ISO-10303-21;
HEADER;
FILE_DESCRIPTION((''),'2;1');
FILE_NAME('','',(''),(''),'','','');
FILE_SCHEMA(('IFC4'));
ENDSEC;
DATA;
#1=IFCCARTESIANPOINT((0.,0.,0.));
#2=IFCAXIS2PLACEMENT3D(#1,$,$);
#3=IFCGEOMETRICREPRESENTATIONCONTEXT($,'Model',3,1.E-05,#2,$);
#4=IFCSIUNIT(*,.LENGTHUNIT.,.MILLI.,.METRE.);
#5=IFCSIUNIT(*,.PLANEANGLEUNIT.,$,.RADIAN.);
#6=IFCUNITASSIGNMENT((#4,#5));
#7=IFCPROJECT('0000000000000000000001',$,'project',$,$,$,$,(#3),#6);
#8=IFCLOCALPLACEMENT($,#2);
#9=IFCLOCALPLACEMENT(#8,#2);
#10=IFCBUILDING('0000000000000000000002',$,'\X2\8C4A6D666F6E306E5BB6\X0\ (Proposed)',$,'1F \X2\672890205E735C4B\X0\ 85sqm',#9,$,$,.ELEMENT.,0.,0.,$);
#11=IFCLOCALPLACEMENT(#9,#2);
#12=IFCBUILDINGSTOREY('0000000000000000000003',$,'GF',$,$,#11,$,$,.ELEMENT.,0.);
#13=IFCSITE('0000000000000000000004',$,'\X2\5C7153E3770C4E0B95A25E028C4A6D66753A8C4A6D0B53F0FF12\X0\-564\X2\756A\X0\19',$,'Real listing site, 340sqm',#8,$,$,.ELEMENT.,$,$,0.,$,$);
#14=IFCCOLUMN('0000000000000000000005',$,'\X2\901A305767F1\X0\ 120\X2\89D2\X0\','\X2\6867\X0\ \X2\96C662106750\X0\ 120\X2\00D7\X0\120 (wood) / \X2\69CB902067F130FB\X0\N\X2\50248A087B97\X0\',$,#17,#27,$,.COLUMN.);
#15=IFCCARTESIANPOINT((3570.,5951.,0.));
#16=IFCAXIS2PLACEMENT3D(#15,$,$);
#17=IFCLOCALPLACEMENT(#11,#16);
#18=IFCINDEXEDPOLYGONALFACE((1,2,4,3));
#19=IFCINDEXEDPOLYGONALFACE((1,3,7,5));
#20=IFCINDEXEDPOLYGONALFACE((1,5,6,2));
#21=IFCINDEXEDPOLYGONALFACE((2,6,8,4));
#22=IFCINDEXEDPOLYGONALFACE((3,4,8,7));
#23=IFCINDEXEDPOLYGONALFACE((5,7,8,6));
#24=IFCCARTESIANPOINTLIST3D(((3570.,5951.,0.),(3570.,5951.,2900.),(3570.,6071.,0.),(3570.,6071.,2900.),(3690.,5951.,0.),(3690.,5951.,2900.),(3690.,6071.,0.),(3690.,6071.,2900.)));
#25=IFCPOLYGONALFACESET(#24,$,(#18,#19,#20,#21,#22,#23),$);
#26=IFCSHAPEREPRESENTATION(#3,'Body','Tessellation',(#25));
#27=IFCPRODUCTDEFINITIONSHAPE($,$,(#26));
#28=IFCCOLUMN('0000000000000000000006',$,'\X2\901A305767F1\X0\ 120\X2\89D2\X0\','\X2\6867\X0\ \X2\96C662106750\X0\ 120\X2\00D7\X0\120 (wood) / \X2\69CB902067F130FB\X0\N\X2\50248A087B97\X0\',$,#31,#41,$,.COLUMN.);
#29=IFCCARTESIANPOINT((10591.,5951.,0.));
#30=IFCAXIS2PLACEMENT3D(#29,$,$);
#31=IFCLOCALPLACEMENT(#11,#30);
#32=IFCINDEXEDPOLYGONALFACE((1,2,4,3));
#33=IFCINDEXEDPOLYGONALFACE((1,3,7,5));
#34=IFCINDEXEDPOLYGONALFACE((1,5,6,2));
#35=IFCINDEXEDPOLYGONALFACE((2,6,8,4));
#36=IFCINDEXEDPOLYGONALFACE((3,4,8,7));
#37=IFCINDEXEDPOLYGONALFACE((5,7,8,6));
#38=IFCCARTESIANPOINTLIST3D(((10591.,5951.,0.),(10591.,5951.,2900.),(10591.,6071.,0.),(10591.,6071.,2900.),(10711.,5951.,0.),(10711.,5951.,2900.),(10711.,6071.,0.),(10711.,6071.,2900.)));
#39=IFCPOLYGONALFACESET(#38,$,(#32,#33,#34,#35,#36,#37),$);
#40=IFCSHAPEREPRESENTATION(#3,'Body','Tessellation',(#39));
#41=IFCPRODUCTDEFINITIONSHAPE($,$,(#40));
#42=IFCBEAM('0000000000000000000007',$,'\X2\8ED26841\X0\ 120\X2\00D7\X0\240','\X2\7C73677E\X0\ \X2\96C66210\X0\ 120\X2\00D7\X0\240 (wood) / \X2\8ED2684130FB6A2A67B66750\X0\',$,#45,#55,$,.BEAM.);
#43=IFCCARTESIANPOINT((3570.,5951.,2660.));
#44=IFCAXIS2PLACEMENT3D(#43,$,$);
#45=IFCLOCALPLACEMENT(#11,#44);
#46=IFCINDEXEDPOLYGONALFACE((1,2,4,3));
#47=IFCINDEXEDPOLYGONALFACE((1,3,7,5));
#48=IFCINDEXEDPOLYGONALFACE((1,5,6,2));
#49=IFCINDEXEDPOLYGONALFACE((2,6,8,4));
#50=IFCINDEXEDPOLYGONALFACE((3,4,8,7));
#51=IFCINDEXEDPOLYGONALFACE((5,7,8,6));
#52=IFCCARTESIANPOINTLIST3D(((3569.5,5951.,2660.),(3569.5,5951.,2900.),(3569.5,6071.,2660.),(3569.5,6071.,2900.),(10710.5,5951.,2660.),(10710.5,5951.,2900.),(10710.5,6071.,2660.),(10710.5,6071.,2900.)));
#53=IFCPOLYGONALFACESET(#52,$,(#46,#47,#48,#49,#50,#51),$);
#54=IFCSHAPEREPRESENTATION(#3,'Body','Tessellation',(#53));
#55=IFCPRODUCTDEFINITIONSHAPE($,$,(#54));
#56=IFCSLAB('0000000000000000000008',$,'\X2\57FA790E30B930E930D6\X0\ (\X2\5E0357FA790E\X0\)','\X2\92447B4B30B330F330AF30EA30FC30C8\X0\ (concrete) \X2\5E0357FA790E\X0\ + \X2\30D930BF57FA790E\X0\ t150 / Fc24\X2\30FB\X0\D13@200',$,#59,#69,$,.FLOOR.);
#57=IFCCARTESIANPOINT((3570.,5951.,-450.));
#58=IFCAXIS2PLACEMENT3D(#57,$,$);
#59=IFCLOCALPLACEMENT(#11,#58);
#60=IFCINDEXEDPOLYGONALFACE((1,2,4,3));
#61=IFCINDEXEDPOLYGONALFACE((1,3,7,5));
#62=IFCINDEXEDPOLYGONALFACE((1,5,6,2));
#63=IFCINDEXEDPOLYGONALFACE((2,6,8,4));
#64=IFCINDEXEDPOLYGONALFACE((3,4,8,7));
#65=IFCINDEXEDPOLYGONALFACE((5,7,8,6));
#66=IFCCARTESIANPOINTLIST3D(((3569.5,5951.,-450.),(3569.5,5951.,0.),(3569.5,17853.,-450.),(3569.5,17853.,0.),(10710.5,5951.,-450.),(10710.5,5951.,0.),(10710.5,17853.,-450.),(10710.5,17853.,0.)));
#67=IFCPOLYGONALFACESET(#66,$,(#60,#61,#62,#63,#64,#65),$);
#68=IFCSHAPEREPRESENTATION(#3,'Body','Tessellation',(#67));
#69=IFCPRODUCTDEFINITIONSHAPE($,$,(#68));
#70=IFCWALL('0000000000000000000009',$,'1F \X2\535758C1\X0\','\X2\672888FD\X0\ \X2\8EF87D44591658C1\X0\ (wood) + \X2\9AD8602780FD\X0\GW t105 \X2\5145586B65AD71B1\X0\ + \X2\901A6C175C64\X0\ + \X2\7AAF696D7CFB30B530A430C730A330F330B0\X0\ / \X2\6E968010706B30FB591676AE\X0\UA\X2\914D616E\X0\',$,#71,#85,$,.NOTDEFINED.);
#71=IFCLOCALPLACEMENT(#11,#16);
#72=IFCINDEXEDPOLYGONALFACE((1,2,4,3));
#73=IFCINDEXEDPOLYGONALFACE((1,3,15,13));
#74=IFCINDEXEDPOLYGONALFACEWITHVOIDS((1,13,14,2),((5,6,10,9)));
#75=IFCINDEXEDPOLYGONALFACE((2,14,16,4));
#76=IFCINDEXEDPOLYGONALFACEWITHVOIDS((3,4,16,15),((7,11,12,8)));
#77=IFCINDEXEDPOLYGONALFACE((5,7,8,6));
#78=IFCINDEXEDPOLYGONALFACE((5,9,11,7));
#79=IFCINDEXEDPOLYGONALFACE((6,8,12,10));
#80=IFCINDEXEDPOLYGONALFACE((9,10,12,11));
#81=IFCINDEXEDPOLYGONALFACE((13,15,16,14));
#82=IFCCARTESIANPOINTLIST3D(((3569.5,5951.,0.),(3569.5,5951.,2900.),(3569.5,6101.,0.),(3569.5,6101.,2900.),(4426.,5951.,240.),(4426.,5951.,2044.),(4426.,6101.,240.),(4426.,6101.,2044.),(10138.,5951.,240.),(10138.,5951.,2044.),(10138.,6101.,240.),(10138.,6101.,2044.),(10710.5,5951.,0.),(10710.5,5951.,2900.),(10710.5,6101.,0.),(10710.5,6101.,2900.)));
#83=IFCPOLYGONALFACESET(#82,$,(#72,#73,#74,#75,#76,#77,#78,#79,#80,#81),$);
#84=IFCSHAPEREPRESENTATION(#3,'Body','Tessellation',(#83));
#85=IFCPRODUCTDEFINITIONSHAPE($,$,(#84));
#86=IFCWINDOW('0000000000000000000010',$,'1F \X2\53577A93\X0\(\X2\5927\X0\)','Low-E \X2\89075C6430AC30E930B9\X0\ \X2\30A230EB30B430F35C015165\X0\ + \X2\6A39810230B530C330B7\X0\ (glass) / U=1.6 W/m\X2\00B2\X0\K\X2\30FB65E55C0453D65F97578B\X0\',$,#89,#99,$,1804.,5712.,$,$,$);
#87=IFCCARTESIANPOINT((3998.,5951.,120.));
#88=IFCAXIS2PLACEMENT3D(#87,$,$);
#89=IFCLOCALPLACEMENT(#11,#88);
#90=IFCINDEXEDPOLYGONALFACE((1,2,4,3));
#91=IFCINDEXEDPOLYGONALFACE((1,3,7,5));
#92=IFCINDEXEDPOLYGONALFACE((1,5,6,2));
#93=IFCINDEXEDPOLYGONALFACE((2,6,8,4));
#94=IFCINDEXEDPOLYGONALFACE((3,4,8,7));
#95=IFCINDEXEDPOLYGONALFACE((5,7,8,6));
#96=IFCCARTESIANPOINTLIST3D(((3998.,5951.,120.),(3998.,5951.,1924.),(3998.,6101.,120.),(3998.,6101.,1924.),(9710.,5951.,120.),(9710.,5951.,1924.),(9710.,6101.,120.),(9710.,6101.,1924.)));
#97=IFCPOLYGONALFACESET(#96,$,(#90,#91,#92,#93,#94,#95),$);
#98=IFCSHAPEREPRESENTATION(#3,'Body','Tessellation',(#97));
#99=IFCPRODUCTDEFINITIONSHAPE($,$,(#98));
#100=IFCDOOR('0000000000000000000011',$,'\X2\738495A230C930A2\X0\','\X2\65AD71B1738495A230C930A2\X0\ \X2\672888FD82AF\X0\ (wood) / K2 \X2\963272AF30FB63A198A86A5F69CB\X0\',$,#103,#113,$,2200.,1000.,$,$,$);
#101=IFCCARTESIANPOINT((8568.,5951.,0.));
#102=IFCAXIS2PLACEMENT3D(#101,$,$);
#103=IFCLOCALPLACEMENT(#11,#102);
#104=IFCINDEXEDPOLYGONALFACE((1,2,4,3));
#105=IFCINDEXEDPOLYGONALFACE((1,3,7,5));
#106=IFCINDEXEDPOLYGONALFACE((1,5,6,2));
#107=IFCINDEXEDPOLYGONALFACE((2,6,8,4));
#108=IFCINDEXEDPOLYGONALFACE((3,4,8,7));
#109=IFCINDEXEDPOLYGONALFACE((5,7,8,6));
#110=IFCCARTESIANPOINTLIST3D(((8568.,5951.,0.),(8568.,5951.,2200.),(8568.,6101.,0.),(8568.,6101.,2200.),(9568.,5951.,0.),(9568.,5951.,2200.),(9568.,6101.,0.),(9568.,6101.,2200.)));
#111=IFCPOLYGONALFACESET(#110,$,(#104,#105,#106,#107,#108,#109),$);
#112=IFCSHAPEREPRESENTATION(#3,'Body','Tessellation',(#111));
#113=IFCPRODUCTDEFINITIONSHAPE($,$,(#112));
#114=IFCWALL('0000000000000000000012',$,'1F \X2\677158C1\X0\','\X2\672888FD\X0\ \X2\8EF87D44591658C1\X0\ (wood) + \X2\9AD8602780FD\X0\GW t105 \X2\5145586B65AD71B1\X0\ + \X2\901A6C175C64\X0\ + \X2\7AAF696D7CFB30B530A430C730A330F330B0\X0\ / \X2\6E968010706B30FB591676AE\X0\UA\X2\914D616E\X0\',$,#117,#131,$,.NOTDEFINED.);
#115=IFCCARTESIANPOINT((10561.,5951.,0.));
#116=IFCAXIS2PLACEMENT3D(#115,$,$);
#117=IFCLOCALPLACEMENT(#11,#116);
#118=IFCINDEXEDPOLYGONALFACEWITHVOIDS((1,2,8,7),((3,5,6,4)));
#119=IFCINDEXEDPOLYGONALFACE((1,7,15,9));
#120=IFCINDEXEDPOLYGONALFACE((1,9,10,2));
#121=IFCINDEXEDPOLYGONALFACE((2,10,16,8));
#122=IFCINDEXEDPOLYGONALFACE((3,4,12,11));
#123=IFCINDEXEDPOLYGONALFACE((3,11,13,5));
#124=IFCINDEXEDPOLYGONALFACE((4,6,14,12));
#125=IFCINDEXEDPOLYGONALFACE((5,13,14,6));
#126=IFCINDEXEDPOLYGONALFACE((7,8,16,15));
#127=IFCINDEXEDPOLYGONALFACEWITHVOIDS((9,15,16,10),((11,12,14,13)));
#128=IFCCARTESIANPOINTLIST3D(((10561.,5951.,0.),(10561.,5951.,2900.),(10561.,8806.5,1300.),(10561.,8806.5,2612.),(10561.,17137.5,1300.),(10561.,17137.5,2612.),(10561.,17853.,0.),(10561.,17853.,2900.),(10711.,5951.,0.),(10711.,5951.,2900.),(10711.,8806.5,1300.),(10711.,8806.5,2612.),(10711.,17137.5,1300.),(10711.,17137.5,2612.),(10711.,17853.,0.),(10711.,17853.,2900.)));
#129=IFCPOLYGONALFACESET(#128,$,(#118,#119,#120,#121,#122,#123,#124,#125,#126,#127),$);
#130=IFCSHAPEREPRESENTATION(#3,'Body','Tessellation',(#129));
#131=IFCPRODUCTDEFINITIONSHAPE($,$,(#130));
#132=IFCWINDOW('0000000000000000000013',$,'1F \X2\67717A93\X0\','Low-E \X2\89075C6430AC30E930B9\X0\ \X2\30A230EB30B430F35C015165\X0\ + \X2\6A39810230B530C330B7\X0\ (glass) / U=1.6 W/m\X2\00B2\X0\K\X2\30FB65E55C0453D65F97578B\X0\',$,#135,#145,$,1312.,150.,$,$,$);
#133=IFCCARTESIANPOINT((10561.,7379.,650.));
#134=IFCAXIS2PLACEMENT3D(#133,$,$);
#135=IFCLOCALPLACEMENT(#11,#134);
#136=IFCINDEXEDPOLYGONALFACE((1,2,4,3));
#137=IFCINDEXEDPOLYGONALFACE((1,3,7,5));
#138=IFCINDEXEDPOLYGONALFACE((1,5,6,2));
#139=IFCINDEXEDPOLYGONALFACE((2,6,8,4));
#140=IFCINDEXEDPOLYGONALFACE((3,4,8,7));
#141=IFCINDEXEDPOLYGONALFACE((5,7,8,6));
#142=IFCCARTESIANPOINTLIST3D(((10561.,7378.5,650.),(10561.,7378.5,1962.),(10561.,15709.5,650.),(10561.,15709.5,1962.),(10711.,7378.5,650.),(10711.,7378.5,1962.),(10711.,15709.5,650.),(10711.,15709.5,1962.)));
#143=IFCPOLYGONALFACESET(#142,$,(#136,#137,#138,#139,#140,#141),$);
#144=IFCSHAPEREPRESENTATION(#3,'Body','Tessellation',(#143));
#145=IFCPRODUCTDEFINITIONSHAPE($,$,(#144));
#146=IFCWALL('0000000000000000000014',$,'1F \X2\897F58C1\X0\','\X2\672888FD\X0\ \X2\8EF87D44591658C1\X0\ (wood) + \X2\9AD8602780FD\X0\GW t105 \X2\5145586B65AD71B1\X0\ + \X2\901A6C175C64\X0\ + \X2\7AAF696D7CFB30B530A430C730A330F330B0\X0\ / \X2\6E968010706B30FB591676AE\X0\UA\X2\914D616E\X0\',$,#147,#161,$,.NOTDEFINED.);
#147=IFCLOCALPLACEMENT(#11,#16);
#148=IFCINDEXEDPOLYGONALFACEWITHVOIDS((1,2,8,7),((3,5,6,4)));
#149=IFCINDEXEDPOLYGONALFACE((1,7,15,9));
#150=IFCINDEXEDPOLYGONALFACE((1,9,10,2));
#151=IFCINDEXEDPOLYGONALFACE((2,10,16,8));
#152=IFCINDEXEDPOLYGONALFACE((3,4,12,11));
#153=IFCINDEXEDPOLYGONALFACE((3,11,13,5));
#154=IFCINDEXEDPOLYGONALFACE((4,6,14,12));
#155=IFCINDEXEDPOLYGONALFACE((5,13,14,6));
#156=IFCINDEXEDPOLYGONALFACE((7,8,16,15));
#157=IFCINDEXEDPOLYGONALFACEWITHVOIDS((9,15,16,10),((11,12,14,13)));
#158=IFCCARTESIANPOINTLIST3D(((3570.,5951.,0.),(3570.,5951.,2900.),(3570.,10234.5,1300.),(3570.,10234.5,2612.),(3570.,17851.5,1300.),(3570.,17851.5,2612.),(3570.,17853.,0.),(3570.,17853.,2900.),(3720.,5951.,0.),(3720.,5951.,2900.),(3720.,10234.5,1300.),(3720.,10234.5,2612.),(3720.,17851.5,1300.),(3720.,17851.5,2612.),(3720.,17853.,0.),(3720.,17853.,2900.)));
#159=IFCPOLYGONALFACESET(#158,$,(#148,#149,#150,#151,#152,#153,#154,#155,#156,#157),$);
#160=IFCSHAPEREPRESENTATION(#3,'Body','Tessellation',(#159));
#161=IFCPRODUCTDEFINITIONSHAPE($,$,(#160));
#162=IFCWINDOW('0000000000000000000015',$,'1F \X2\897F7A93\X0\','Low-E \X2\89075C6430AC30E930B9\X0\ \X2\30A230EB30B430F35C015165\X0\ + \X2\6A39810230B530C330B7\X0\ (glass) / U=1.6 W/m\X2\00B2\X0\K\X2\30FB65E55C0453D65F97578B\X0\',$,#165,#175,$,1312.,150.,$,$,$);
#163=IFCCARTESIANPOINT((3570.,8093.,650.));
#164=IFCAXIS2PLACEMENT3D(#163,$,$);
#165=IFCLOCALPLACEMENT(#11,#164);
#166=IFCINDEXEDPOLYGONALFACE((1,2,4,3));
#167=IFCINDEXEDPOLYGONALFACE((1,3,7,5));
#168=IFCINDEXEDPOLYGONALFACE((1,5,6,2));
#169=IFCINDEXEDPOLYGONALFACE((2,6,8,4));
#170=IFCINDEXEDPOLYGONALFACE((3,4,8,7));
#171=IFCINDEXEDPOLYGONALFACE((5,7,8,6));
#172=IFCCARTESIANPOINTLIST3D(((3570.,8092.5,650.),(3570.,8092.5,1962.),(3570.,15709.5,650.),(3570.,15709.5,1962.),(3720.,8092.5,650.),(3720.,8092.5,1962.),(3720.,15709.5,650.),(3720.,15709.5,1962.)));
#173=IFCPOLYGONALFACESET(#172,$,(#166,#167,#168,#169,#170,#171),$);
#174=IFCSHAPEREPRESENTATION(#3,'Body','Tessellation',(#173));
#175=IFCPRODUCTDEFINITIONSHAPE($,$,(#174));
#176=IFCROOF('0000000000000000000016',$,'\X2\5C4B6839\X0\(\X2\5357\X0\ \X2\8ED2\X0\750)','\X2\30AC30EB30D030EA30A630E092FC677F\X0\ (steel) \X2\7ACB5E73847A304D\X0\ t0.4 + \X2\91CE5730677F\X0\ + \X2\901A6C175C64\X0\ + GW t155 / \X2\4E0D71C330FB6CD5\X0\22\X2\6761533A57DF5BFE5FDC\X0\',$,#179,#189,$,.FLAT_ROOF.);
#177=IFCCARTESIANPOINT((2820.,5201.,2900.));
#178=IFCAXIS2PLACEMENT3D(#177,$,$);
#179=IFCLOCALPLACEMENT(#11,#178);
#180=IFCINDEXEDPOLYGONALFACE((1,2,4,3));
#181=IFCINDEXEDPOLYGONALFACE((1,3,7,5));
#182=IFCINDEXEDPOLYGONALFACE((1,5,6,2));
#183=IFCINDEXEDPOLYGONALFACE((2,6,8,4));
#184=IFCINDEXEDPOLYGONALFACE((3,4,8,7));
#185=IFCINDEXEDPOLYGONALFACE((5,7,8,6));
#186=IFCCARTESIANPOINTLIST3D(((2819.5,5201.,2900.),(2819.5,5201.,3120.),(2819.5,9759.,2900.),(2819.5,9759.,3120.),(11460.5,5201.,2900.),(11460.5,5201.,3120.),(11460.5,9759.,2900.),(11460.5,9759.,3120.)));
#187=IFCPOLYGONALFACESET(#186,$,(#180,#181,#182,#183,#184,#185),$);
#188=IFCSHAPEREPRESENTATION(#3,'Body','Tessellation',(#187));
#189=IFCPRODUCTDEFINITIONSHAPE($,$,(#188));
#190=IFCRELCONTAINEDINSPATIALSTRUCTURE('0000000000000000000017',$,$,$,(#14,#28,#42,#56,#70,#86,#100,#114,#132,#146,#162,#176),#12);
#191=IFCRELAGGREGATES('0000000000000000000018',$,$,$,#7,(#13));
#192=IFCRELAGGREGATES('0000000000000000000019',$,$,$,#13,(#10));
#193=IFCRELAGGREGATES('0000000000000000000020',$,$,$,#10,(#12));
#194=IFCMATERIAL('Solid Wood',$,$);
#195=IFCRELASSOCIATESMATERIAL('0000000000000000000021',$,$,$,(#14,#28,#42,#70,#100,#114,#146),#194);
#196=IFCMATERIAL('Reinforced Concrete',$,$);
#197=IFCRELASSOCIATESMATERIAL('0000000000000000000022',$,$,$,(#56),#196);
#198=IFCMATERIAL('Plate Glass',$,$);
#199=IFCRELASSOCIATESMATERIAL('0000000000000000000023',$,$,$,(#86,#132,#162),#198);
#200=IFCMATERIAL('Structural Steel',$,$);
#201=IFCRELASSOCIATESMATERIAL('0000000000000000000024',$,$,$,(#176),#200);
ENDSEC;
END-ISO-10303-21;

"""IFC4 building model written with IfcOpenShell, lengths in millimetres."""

from ifc_helpers import new_model, si_unit, frame, frame_2d, origin, place, context, project, spatial, rectangle, extrude, material, element, fill, save


model = new_model("IFC4")

# Units and contexts
model_context = context("Model", 3, precision=1e-05, world=origin())
ifc_project = project(units=[si_unit("LENGTHUNIT", "METRE", prefix="MILLI"), si_unit("PLANEANGLEUNIT", "RADIAN")], contexts=[model_context])

# Site, building, storey
site_placement = place(None, origin())
site = spatial("IfcSite", under=ifc_project, at=site_placement, Name="山口県下関市豊浦町豊洋台２-564番19", ObjectType="Real listing site, 340sqm", CompositionType="ELEMENT", RefElevation=0.0)
building_placement = place(site_placement, origin())
building = spatial("IfcBuilding", under=site, at=building_placement, Name="豊浦潮の家 (Proposed)", ObjectType="1F 木造平屋 85sqm", CompositionType="ELEMENT", ElevationOfRefHeight=0.0, ElevationOfTerrain=0.0)
storey_placement = place(building_placement, origin())
storey = spatial("IfcBuildingStorey", under=building, at=storey_placement, Name="GF", CompositionType="ELEMENT", Elevation=0.0)

# Columns
ifc_material_1 = material(Name="Solid Wood")
column_1_placement = place(storey_placement, frame((3570.0, 5951.0, 0.0)))
element("IfcColumn", 1, at=column_1_placement, inside=storey, material=ifc_material_1, Name="通し柱 120角", Description="桧 集成材 120×120 (wood) / 構造柱・N値計算", PredefinedType="COLUMN", context=model_context, shape_type="SweptSolid", body=[
    extrude(rectangle(XDim=120.0, YDim=120.0, at=frame_2d((60.0, 60.0))), frame((3570.0, 5951.0, 0.0)), (0.0, 0.0, 1.0), 2900.0),
])
column_2_placement = place(storey_placement, frame((10591.0, 5951.0, 0.0)))
element("IfcColumn", 2, at=column_2_placement, inside=storey, material=ifc_material_1, Name="通し柱 120角", Description="桧 集成材 120×120 (wood) / 構造柱・N値計算", PredefinedType="COLUMN", context=model_context, shape_type="SweptSolid", body=[
    extrude(rectangle(XDim=120.0, YDim=120.0, at=frame_2d((60.0, 60.0))), frame((10591.0, 5951.0, 0.0)), (0.0, 0.0, 1.0), 2900.0),
])

# Beam
beam_1_placement = place(storey_placement, frame((3570.0, 5951.0, 2660.0)))
element("IfcBeam", 3, at=beam_1_placement, inside=storey, material=ifc_material_1, Name="軒桁 120×240", Description="米松 集成 120×240 (wood) / 軒桁・横架材", PredefinedType="BEAM", context=model_context, shape_type="SweptSolid", body=[
    extrude(rectangle(XDim=7141.0, YDim=120.0, at=frame_2d((3570.0, 60.0))), frame((3570.0, 5951.0, 2660.0)), (0.0, 0.0, 1.0), 240.0),
])

# Slab
ifc_material_2 = material(Name="Reinforced Concrete")
slab_1_placement = place(storey_placement, frame((3570.0, 5951.0, -450.0)))
element("IfcSlab", 4, at=slab_1_placement, inside=storey, material=ifc_material_2, Name="基礎スラブ (布基礎)", Description="鉄筋コンクリート (concrete) 布基礎 + ベタ基礎 t150 / Fc24・D13@200", PredefinedType="FLOOR", context=model_context, shape_type="SweptSolid", body=[
    extrude(rectangle(XDim=7141.0, YDim=11902.0, at=frame_2d((3570.0, 5951.0))), frame((3570.0, 5951.0, -450.0)), (0.0, 0.0, 1.0), 450.0),
])

# Wall, openings, window, door
wall_1_placement = place(storey_placement, frame((3570.0, 5951.0, 0.0)))
wall_1 = element("IfcWall", 5, at=wall_1_placement, inside=storey, material=ifc_material_1, Name="1F 南壁", Description="木製 軸組外壁 (wood) + 高性能GW t105 充填断熱 + 通気層 + 窯業系サイディング / 準耐火・外皮UA配慮", PredefinedType="NOTDEFINED", context=model_context, shape_type="SweptSolid", body=[
    extrude(rectangle(XDim=7141.0, YDim=150.0, at=frame_2d((3570.0, 75.0))), frame((3570.0, 5951.0, 0.0)), (0.0, 0.0, 1.0), 2900.0),
])
opening_1_placement = place(storey_placement, frame((3998.0, 5951.0, 120.0)))
opening_1 = element("IfcOpeningElement", 6, at=opening_1_placement, cuts=wall_1, PredefinedType="NOTDEFINED", context=model_context, shape_type="SweptSolid", body=[
    extrude(rectangle(XDim=5712.0, YDim=150.0, at=frame_2d((2856.0, 75.0))), frame((3998.0, 5951.0, 120.0)), (0.0, 0.0, 1.0), 1804.0),
])
opening_2_placement = place(storey_placement, frame((8568.0, 5951.0, 0.0)))
opening_2 = element("IfcOpeningElement", 7, at=opening_2_placement, cuts=wall_1, PredefinedType="NOTDEFINED", context=model_context, shape_type="SweptSolid", body=[
    extrude(rectangle(XDim=1000.0, YDim=150.0, at=frame_2d((500.0, 75.0))), frame((8568.0, 5951.0, 0.0)), (0.0, 0.0, 1.0), 2200.0),
])
ifc_material_3 = material(Name="Plate Glass")
window_1_placement = place(storey_placement, frame((3998.0, 5951.0, 120.0)))
window_1 = element("IfcWindow", 8, at=window_1_placement, inside=storey, material=ifc_material_3, Name="1F 南窓(大)", Description="Low-E 複層ガラス アルゴン封入 + 樹脂サッシ (glass) / U=1.6 W/m²K・日射取得型", OverallHeight=1804.0, OverallWidth=5712.0, context=model_context, shape_type="SweptSolid", body=[
    extrude(rectangle(XDim=5712.0, YDim=150.0, at=frame_2d((2856.0, 75.0))), frame((3998.0, 5951.0, 120.0)), (0.0, 0.0, 1.0), 1804.0),
])
fill(opening_1, window_1)
door_placement = place(storey_placement, frame((8568.0, 5951.0, 0.0)))
door = element("IfcDoor", 9, at=door_placement, inside=storey, material=ifc_material_1, Name="玄関ドア", Description="断熱玄関ドア 木製芯 (wood) / K2 防犯・採風機構", OverallHeight=2200.0, OverallWidth=1000.0, context=model_context, shape_type="SweptSolid", body=[
    extrude(rectangle(XDim=1000.0, YDim=150.0, at=frame_2d((500.0, 75.0))), frame((8568.0, 5951.0, 0.0)), (0.0, 0.0, 1.0), 2200.0),
])
fill(opening_2, door)

# Walls, openings, windows
wall_2_placement = place(storey_placement, frame((10561.0, 5951.0, 0.0)))
wall_2 = element("IfcWall", 10, at=wall_2_placement, inside=storey, material=ifc_material_1, Name="1F 東壁", Description="木製 軸組外壁 (wood) + 高性能GW t105 充填断熱 + 通気層 + 窯業系サイディング / 準耐火・外皮UA配慮", PredefinedType="NOTDEFINED", context=model_context, shape_type="SweptSolid", body=[
    extrude(rectangle(XDim=150.0, YDim=11902.0, at=frame_2d((75.0, 5951.0))), frame((10561.0, 5951.0, 0.0)), (0.0, 0.0, 1.0), 2900.0),
])
opening_3_placement = place(storey_placement, frame((10561.0, 7379.0, 650.0)))
opening_3 = element("IfcOpeningElement", 11, at=opening_3_placement, cuts=wall_2, PredefinedType="NOTDEFINED", context=model_context, shape_type="SweptSolid", body=[
    extrude(rectangle(XDim=150.0, YDim=8331.0, at=frame_2d((75.0, 4165.0))), frame((10561.0, 7379.0, 650.0)), (0.0, 0.0, 1.0), 1312.0),
])
window_2_placement = place(storey_placement, frame((10561.0, 7379.0, 650.0)))
window_2 = element("IfcWindow", 12, at=window_2_placement, inside=storey, material=ifc_material_3, Name="1F 東窓", Description="Low-E 複層ガラス アルゴン封入 + 樹脂サッシ (glass) / U=1.6 W/m²K・日射取得型", OverallHeight=1312.0, OverallWidth=150.0, context=model_context, shape_type="SweptSolid", body=[
    extrude(rectangle(XDim=150.0, YDim=8331.0, at=frame_2d((75.0, 4165.0))), frame((10561.0, 7379.0, 650.0)), (0.0, 0.0, 1.0), 1312.0),
])
fill(opening_3, window_2)
wall_3_placement = place(storey_placement, frame((3570.0, 5951.0, 0.0)))
wall_3 = element("IfcWall", 13, at=wall_3_placement, inside=storey, material=ifc_material_1, Name="1F 西壁", Description="木製 軸組外壁 (wood) + 高性能GW t105 充填断熱 + 通気層 + 窯業系サイディング / 準耐火・外皮UA配慮", PredefinedType="NOTDEFINED", context=model_context, shape_type="SweptSolid", body=[
    extrude(rectangle(XDim=150.0, YDim=11902.0, at=frame_2d((75.0, 5951.0))), frame((3570.0, 5951.0, 0.0)), (0.0, 0.0, 1.0), 2900.0),
])
opening_4_placement = place(storey_placement, frame((3570.0, 8093.0, 650.0)))
opening_4 = element("IfcOpeningElement", 14, at=opening_4_placement, cuts=wall_3, PredefinedType="NOTDEFINED", context=model_context, shape_type="SweptSolid", body=[
    extrude(rectangle(XDim=150.0, YDim=7617.0, at=frame_2d((75.0, 3808.0))), frame((3570.0, 8093.0, 650.0)), (0.0, 0.0, 1.0), 1312.0),
])
window_3_placement = place(storey_placement, frame((3570.0, 8093.0, 650.0)))
window_3 = element("IfcWindow", 15, at=window_3_placement, inside=storey, material=ifc_material_3, Name="1F 西窓", Description="Low-E 複層ガラス アルゴン封入 + 樹脂サッシ (glass) / U=1.6 W/m²K・日射取得型", OverallHeight=1312.0, OverallWidth=150.0, context=model_context, shape_type="SweptSolid", body=[
    extrude(rectangle(XDim=150.0, YDim=7617.0, at=frame_2d((75.0, 3808.0))), frame((3570.0, 8093.0, 650.0)), (0.0, 0.0, 1.0), 1312.0),
])
fill(opening_4, window_3)

# Roof
ifc_material_4 = material(Name="Structural Steel")
roof_placement = place(storey_placement, frame((2820.0, 5201.0, 2900.0)))
element("IfcRoof", 16, at=roof_placement, inside=storey, material=ifc_material_4, Name="屋根(南 軒750)", Description="ガルバリウム鋼板 (steel) 立平葺き t0.4 + 野地板 + 通気層 + GW t155 / 不燃・法22条区域対応", PredefinedType="FLAT_ROOF", context=model_context, shape_type="SweptSolid", body=[
    extrude(rectangle(XDim=8641.0, YDim=4558.0, at=frame_2d((4320.0, 2279.0))), frame((2820.0, 5201.0, 2900.0)), (0.0, 0.0, 1.0), 220.0),
])

save(model, "model.ifc")
